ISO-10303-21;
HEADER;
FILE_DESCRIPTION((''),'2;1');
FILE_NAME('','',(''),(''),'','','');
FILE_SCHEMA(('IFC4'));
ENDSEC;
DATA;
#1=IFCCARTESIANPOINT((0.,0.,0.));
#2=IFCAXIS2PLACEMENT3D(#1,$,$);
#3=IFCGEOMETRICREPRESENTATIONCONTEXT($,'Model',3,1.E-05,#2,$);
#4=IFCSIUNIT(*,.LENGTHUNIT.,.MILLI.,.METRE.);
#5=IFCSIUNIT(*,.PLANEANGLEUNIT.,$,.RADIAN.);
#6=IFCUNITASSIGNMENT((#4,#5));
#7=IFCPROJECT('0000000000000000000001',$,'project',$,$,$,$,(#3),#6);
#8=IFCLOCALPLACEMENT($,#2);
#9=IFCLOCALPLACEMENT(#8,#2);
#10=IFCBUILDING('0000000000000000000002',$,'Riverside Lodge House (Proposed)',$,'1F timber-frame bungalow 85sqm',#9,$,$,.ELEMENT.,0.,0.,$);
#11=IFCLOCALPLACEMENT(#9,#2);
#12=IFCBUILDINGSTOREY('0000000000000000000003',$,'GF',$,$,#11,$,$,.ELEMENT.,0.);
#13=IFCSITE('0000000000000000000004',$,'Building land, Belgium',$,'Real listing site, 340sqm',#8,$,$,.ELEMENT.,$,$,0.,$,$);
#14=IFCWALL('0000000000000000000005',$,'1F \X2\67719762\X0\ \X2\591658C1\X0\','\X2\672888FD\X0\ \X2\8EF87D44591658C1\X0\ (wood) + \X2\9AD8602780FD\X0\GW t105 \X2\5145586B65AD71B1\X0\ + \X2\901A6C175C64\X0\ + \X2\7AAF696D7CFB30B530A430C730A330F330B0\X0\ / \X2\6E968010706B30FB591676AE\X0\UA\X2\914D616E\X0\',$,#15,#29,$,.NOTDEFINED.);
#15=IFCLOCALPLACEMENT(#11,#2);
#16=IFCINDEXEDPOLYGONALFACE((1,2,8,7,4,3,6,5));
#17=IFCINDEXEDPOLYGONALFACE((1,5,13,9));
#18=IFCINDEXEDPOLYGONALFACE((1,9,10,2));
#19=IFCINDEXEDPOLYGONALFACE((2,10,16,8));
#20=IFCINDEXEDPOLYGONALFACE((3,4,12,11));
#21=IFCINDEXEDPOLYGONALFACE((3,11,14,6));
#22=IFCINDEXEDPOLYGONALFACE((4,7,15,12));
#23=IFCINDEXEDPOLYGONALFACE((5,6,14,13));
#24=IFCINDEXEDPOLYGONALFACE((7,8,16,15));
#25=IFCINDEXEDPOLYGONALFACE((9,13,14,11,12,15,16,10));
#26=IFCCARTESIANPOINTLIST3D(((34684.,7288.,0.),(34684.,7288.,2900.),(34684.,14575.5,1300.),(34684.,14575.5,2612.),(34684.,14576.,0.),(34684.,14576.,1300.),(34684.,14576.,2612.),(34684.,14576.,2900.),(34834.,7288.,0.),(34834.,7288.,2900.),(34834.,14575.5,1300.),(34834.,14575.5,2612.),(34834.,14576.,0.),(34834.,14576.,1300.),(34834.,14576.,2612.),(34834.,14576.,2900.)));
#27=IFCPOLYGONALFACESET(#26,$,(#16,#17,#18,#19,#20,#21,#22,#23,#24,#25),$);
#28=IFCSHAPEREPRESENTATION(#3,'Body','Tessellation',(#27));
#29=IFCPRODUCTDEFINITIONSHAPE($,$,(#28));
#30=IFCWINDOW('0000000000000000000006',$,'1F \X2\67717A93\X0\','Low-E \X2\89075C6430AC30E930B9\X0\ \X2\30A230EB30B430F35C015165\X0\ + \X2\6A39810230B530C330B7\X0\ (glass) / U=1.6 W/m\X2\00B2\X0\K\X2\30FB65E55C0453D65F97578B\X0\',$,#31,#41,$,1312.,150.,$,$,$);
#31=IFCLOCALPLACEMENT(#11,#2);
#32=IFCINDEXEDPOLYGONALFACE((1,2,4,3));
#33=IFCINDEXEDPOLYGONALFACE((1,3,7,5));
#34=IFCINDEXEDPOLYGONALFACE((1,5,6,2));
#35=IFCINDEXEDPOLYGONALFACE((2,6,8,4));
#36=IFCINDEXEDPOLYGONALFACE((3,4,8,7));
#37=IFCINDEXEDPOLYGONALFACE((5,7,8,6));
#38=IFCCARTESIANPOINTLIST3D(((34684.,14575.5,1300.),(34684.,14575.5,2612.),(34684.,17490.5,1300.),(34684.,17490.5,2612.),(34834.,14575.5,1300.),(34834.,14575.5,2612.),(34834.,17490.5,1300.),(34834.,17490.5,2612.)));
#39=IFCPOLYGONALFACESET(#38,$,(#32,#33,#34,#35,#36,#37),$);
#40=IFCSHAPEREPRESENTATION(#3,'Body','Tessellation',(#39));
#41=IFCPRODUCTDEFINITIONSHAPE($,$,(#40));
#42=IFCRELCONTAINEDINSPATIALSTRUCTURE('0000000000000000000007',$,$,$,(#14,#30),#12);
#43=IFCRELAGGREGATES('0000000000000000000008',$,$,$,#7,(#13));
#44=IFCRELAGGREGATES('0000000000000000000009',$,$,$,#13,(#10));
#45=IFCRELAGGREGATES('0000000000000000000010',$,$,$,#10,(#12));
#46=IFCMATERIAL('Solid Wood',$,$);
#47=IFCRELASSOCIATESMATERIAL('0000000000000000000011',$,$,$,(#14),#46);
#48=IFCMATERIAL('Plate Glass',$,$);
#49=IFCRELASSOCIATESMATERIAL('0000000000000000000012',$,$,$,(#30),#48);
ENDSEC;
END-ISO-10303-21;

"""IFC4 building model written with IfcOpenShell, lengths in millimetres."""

from ifc_helpers import new_model, si_unit, frame, frame_2d, origin, place, context, project, spatial, rectangle, extrude, material, element, fill, save


model = new_model("IFC4")

# Units and contexts
model_context = context("Model", 3, precision=1e-05, world=origin())
ifc_project = project(units=[si_unit("LENGTHUNIT", "METRE", prefix="MILLI"), si_unit("PLANEANGLEUNIT", "RADIAN")], contexts=[model_context])

# Site, building, storey
site_placement = place(None, origin())
site = spatial("IfcSite", under=ifc_project, at=site_placement, Name="Building land, Belgium", ObjectType="Real listing site, 340sqm", CompositionType="ELEMENT", RefElevation=0.0)
building_placement = place(site_placement, origin())
building = spatial("IfcBuilding", under=site, at=building_placement, Name="Riverside Lodge House (Proposed)", ObjectType="1F timber-frame bungalow 85sqm", CompositionType="ELEMENT", ElevationOfRefHeight=0.0, ElevationOfTerrain=0.0)
storey_placement = place(building_placement, origin())
storey = spatial("IfcBuildingStorey", under=building, at=storey_placement, Name="GF", CompositionType="ELEMENT", Elevation=0.0)

# Shared definitions
ifc_material_1 = material(Name="Solid Wood")

# Wall, opening, window
wall_1_placement = place(storey_placement, frame((17342.0, 3644.0, 0.0)))
wall_1 = element("IfcWall", 1, at=wall_1_placement, inside=storey, material=ifc_material_1, Name="1F 東面 外壁", Description="木製 軸組外壁 (wood) + 高性能GW t105 充填断熱 + 通気層 + 窯業系サイディング / 準耐火・外皮UA配慮", PredefinedType="NOTDEFINED", context=model_context, shape_type="SweptSolid", body=[
    extrude(rectangle(XDim=150.0, YDim=7288.0, at=frame_2d((75.0, 3644.0))), frame((17342.0, 3644.0, 0.0)), (0.0, 0.0, 1.0), 2900.0),
])
opening_placement = place(storey_placement, frame((17342.0, 7288.0, 650.0)))
opening = element("IfcOpeningElement", 2, at=opening_placement, cuts=wall_1, PredefinedType="NOTDEFINED", context=model_context, shape_type="SweptSolid", body=[
    extrude(rectangle(XDim=150.0, YDim=2915.0, at=frame_2d((75.0, 1457.0))), frame((17342.0, 7288.0, 650.0)), (0.0, 0.0, 1.0), 1312.0),
])
ifc_material_2 = material(Name="Plate Glass")
window_1_placement = place(storey_placement, frame((17342.0, 7288.0, 650.0)))
window_1 = element("IfcWindow", 3, at=window_1_placement, inside=storey, material=ifc_material_2, Name="1F 東窓", Description="Low-E 複層ガラス アルゴン封入 + 樹脂サッシ (glass) / U=1.6 W/m²K・日射取得型", OverallHeight=1312.0, OverallWidth=150.0, context=model_context, shape_type="SweptSolid", body=[
    extrude(rectangle(XDim=150.0, YDim=2915.0, at=frame_2d((75.0, 1457.0))), frame((17342.0, 7288.0, 650.0)), (0.0, 0.0, 1.0), 1312.0),
])
fill(opening, window_1)

save(model, "model.ifc")
